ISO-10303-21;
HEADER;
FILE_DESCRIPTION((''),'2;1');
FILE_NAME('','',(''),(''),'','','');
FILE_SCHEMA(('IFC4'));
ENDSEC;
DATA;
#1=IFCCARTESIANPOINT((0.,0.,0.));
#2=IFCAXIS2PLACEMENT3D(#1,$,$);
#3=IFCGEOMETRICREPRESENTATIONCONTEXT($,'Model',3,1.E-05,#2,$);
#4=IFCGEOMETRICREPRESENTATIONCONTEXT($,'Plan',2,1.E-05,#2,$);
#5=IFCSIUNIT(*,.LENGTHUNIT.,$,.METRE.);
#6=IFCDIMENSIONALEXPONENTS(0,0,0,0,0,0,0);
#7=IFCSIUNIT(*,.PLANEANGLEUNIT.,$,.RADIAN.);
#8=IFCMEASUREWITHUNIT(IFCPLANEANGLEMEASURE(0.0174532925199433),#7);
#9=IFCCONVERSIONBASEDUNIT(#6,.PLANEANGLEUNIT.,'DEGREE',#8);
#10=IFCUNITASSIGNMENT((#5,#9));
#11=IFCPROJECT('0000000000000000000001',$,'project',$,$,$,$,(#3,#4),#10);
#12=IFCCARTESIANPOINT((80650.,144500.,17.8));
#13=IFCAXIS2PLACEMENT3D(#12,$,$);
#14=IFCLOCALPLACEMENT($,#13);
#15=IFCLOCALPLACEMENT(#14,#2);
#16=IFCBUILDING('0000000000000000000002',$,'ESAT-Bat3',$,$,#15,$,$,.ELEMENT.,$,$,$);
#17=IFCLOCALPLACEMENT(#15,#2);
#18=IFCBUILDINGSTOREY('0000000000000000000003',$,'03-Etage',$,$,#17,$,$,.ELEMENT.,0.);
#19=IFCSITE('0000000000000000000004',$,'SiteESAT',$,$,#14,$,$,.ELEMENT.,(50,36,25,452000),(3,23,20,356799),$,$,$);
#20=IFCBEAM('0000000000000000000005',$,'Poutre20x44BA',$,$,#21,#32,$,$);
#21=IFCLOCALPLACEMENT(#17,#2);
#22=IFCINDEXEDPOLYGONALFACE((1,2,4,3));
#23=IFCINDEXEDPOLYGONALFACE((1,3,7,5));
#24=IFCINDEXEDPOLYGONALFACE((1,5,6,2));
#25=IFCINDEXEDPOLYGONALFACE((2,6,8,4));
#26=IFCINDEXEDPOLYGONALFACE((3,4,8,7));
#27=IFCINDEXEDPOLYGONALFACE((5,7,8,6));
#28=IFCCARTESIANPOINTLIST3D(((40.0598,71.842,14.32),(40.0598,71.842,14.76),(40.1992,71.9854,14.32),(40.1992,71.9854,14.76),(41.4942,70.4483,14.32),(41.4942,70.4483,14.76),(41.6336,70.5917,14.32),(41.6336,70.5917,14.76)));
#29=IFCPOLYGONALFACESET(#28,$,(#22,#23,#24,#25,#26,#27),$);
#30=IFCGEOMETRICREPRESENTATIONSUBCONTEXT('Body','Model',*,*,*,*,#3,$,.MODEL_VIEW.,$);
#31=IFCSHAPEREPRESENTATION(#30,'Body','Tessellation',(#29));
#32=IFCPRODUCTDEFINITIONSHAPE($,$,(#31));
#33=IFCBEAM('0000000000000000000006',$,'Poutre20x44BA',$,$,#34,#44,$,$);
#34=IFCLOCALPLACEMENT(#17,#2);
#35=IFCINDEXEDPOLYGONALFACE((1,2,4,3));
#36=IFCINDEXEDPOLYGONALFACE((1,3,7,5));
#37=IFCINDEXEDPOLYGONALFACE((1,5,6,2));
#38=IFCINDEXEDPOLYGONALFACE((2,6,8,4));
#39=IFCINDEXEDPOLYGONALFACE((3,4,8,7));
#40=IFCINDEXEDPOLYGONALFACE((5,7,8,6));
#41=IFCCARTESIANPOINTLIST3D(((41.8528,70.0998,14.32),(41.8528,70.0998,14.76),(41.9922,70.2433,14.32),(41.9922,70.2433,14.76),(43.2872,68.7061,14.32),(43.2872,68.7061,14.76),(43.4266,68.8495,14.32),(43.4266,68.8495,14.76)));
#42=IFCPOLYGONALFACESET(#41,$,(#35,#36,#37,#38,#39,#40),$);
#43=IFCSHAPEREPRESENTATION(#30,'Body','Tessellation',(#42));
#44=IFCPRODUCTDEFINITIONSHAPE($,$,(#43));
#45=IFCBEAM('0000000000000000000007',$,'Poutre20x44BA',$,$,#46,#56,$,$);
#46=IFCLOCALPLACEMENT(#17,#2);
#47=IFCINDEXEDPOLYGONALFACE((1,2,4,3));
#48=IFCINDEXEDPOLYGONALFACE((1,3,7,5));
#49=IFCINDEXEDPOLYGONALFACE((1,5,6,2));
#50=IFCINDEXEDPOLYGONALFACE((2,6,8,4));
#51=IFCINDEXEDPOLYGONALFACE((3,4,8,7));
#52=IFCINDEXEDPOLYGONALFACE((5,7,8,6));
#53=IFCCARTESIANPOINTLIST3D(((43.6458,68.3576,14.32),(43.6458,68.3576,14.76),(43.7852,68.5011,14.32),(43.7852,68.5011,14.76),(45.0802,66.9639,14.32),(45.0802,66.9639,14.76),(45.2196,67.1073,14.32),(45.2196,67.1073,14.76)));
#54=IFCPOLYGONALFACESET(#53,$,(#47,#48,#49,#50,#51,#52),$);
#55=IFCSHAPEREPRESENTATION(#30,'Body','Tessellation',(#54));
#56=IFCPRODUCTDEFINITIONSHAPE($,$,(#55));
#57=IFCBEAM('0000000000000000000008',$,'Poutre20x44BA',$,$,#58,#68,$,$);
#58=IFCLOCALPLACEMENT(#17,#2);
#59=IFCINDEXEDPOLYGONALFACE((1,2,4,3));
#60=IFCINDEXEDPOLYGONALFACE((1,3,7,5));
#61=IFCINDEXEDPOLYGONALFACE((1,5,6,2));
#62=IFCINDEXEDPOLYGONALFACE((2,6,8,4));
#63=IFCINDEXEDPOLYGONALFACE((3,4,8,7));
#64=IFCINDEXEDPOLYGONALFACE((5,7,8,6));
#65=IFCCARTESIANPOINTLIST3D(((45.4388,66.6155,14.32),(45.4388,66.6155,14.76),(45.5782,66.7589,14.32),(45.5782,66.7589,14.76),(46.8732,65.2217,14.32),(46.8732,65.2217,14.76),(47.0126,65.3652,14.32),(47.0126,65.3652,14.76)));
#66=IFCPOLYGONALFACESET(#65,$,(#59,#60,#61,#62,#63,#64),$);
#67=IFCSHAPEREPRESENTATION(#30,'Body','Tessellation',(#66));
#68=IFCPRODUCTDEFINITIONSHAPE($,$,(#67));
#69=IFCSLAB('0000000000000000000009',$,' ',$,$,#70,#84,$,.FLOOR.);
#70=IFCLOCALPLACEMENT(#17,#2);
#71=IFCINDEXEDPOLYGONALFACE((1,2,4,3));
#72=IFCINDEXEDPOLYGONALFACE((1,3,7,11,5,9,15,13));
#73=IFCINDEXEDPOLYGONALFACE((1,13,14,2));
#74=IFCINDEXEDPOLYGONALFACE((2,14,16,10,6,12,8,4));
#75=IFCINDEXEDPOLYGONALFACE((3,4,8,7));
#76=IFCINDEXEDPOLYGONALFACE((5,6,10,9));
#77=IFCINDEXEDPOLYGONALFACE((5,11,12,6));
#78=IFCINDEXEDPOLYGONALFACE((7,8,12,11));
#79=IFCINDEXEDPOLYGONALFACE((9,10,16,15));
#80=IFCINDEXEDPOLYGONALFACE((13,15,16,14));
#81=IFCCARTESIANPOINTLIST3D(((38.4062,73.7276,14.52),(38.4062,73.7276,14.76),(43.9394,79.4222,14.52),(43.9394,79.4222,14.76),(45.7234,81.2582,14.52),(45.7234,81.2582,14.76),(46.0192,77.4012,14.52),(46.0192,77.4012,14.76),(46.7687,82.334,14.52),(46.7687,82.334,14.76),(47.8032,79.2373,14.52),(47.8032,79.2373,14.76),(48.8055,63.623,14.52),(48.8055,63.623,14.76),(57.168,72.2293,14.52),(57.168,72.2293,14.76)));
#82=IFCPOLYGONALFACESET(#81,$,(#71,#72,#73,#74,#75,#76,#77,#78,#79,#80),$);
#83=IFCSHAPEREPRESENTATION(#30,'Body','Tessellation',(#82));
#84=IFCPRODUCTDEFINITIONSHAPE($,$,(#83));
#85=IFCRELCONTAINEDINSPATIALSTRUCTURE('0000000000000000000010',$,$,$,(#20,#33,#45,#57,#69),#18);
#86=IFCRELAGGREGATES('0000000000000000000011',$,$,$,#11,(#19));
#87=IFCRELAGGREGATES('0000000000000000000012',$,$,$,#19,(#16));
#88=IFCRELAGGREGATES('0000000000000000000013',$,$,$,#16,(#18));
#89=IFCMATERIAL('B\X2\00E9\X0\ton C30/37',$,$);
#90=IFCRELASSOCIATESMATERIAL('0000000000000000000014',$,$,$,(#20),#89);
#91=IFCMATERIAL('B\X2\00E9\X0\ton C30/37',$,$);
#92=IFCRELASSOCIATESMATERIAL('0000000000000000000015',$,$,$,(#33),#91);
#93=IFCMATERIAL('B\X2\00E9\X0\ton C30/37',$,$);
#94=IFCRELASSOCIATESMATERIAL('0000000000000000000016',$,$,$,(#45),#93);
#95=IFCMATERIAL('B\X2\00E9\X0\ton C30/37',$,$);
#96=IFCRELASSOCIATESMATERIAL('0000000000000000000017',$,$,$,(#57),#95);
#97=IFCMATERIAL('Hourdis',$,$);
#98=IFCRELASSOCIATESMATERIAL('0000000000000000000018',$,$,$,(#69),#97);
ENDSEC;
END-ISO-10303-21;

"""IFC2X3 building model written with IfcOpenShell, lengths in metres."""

from ifc_helpers import new_model, entity, si_unit, converted_unit, frame, frame_2d, origin, origin_with_axes, place, context, subcontext, project, spatial, polyline, rectangle, outline, extrude, material, element, save


model = new_model("IFC2X3")

# Units and contexts
model_context = context("Model", 3, precision=1e-05, world=origin())
plan_context = context("Plan", 2, precision=1e-05, world=origin())
body_context = subcontext(model_context, "Body", "Model", "MODEL_VIEW")
ifc_project = project(units=[si_unit("LENGTHUNIT", "METRE"), converted_unit("PLANEANGLEUNIT", "DEGREE", entity("IfcPlaneAngleMeasure", 0.0174532925199433), si_unit("PLANEANGLEUNIT", "RADIAN"), dimensions=[0, 0, 0, 0, 0, 0, 0])], contexts=[model_context, plan_context])

# Site, building, storey
site_placement = place(None, frame((80650.0, 144500.0, 17.8)))
site = spatial("IfcSite", under=ifc_project, at=site_placement, Name="SiteESAT", CompositionType="ELEMENT", RefLatitude=(50, 36, 25, 452000), RefLongitude=(3, 23, 20, 356799))
building_placement = place(site_placement, origin())
building = spatial("IfcBuilding", under=site, at=building_placement, Name="ESAT-Bat3", CompositionType="ELEMENT")
storey_placement = place(building_placement, origin())
storey = spatial("IfcBuildingStorey", under=building, at=storey_placement, Name="03-Etage", CompositionType="ELEMENT", Elevation=0.0)

# Beams
ifc_material_1 = material(Name="Béton C30/37")
beam_1_placement = place(storey_placement, frame((41.6336, 70.5917, 14.32), z_axis=(0.0, 0.0, 1.0), x_axis=(-0.717196, 0.696872, 0.0)))
element("IfcBeam", 1, at=beam_1_placement, inside=storey, material=ifc_material_1, Name="Poutre20x44BA", context=body_context, shape_type="SweptSolid", body=[
    extrude(rectangle(XDim=0.2, YDim=0.44, at=frame_2d((0.1, 0.22), x_axis=(1.0, 0.0))), frame((0.0, 0.0, 0.0), z_axis=(1.0, 0.0, 0.0), x_axis=(0.0, 1.0, 0.0)), (0.0, 0.0, 1.0), 2.0),
])
ifc_material_2 = material(Name="Béton C30/37")
beam_2_placement = place(storey_placement, frame((43.4266, 68.8495, 14.32), z_axis=(0.0, 0.0, 1.0), x_axis=(-0.717196, 0.696872, 0.0)))
element("IfcBeam", 2, at=beam_2_placement, inside=storey, material=ifc_material_2, Name="Poutre20x44BA", context=body_context, shape_type="SweptSolid", body=[
    extrude(rectangle(XDim=0.2, YDim=0.44, at=frame_2d((0.1, 0.22), x_axis=(1.0, 0.0))), frame((0.0, 0.0, 0.0), z_axis=(1.0, 0.0, 0.0), x_axis=(0.0, 1.0, 0.0)), (0.0, 0.0, 1.0), 2.0),
])
ifc_material_3 = material(Name="Béton C30/37")
beam_3_placement = place(storey_placement, frame((45.2196, 67.1073, 14.32), z_axis=(0.0, 0.0, 1.0), x_axis=(-0.717196, 0.696872, 0.0)))
element("IfcBeam", 3, at=beam_3_placement, inside=storey, material=ifc_material_3, Name="Poutre20x44BA", context=body_context, shape_type="SweptSolid", body=[
    extrude(rectangle(XDim=0.2, YDim=0.44, at=frame_2d((0.1, 0.22), x_axis=(1.0, 0.0))), frame((0.0, 0.0, 0.0), z_axis=(1.0, 0.0, 0.0), x_axis=(0.0, 1.0, 0.0)), (0.0, 0.0, 1.0), 2.0),
])
ifc_material_4 = material(Name="Béton C30/37")
beam_4_placement = place(storey_placement, frame((47.0126, 65.3652, 14.32), z_axis=(0.0, 0.0, 1.0), x_axis=(-0.717196, 0.696872, 0.0)))
element("IfcBeam", 4, at=beam_4_placement, inside=storey, material=ifc_material_4, Name="Poutre20x44BA", context=body_context, shape_type="SweptSolid", body=[
    extrude(rectangle(XDim=0.2, YDim=0.44, at=frame_2d((0.1, 0.22), x_axis=(1.0, 0.0))), frame((0.0, 0.0, 0.0), z_axis=(1.0, 0.0, 0.0), x_axis=(0.0, 1.0, 0.0)), (0.0, 0.0, 1.0), 2.0),
])

# Slab
ifc_material_5 = material(Name="Hourdis")
slab_placement = place(storey_placement, frame((38.4062, 63.623, 14.52)))
element("IfcSlab", 5, at=slab_placement, inside=storey, material=ifc_material_5, Name=" ", PredefinedType="FLOOR", context=body_context, shape_type="SweptSolid", body=[
    extrude(outline(polyline([(5.5332, 15.7992), (0.0, 10.1046), (10.3993, 0.0), (18.7618, 8.6063), (8.3625, 18.711), (7.3172, 17.6352), (9.397, 15.6143), (7.613, 13.7782), (5.5332, 15.7992)])), origin_with_axes(), (0.0, 0.0, 1.0), 0.24),
])

save(model, "model.ifc")
